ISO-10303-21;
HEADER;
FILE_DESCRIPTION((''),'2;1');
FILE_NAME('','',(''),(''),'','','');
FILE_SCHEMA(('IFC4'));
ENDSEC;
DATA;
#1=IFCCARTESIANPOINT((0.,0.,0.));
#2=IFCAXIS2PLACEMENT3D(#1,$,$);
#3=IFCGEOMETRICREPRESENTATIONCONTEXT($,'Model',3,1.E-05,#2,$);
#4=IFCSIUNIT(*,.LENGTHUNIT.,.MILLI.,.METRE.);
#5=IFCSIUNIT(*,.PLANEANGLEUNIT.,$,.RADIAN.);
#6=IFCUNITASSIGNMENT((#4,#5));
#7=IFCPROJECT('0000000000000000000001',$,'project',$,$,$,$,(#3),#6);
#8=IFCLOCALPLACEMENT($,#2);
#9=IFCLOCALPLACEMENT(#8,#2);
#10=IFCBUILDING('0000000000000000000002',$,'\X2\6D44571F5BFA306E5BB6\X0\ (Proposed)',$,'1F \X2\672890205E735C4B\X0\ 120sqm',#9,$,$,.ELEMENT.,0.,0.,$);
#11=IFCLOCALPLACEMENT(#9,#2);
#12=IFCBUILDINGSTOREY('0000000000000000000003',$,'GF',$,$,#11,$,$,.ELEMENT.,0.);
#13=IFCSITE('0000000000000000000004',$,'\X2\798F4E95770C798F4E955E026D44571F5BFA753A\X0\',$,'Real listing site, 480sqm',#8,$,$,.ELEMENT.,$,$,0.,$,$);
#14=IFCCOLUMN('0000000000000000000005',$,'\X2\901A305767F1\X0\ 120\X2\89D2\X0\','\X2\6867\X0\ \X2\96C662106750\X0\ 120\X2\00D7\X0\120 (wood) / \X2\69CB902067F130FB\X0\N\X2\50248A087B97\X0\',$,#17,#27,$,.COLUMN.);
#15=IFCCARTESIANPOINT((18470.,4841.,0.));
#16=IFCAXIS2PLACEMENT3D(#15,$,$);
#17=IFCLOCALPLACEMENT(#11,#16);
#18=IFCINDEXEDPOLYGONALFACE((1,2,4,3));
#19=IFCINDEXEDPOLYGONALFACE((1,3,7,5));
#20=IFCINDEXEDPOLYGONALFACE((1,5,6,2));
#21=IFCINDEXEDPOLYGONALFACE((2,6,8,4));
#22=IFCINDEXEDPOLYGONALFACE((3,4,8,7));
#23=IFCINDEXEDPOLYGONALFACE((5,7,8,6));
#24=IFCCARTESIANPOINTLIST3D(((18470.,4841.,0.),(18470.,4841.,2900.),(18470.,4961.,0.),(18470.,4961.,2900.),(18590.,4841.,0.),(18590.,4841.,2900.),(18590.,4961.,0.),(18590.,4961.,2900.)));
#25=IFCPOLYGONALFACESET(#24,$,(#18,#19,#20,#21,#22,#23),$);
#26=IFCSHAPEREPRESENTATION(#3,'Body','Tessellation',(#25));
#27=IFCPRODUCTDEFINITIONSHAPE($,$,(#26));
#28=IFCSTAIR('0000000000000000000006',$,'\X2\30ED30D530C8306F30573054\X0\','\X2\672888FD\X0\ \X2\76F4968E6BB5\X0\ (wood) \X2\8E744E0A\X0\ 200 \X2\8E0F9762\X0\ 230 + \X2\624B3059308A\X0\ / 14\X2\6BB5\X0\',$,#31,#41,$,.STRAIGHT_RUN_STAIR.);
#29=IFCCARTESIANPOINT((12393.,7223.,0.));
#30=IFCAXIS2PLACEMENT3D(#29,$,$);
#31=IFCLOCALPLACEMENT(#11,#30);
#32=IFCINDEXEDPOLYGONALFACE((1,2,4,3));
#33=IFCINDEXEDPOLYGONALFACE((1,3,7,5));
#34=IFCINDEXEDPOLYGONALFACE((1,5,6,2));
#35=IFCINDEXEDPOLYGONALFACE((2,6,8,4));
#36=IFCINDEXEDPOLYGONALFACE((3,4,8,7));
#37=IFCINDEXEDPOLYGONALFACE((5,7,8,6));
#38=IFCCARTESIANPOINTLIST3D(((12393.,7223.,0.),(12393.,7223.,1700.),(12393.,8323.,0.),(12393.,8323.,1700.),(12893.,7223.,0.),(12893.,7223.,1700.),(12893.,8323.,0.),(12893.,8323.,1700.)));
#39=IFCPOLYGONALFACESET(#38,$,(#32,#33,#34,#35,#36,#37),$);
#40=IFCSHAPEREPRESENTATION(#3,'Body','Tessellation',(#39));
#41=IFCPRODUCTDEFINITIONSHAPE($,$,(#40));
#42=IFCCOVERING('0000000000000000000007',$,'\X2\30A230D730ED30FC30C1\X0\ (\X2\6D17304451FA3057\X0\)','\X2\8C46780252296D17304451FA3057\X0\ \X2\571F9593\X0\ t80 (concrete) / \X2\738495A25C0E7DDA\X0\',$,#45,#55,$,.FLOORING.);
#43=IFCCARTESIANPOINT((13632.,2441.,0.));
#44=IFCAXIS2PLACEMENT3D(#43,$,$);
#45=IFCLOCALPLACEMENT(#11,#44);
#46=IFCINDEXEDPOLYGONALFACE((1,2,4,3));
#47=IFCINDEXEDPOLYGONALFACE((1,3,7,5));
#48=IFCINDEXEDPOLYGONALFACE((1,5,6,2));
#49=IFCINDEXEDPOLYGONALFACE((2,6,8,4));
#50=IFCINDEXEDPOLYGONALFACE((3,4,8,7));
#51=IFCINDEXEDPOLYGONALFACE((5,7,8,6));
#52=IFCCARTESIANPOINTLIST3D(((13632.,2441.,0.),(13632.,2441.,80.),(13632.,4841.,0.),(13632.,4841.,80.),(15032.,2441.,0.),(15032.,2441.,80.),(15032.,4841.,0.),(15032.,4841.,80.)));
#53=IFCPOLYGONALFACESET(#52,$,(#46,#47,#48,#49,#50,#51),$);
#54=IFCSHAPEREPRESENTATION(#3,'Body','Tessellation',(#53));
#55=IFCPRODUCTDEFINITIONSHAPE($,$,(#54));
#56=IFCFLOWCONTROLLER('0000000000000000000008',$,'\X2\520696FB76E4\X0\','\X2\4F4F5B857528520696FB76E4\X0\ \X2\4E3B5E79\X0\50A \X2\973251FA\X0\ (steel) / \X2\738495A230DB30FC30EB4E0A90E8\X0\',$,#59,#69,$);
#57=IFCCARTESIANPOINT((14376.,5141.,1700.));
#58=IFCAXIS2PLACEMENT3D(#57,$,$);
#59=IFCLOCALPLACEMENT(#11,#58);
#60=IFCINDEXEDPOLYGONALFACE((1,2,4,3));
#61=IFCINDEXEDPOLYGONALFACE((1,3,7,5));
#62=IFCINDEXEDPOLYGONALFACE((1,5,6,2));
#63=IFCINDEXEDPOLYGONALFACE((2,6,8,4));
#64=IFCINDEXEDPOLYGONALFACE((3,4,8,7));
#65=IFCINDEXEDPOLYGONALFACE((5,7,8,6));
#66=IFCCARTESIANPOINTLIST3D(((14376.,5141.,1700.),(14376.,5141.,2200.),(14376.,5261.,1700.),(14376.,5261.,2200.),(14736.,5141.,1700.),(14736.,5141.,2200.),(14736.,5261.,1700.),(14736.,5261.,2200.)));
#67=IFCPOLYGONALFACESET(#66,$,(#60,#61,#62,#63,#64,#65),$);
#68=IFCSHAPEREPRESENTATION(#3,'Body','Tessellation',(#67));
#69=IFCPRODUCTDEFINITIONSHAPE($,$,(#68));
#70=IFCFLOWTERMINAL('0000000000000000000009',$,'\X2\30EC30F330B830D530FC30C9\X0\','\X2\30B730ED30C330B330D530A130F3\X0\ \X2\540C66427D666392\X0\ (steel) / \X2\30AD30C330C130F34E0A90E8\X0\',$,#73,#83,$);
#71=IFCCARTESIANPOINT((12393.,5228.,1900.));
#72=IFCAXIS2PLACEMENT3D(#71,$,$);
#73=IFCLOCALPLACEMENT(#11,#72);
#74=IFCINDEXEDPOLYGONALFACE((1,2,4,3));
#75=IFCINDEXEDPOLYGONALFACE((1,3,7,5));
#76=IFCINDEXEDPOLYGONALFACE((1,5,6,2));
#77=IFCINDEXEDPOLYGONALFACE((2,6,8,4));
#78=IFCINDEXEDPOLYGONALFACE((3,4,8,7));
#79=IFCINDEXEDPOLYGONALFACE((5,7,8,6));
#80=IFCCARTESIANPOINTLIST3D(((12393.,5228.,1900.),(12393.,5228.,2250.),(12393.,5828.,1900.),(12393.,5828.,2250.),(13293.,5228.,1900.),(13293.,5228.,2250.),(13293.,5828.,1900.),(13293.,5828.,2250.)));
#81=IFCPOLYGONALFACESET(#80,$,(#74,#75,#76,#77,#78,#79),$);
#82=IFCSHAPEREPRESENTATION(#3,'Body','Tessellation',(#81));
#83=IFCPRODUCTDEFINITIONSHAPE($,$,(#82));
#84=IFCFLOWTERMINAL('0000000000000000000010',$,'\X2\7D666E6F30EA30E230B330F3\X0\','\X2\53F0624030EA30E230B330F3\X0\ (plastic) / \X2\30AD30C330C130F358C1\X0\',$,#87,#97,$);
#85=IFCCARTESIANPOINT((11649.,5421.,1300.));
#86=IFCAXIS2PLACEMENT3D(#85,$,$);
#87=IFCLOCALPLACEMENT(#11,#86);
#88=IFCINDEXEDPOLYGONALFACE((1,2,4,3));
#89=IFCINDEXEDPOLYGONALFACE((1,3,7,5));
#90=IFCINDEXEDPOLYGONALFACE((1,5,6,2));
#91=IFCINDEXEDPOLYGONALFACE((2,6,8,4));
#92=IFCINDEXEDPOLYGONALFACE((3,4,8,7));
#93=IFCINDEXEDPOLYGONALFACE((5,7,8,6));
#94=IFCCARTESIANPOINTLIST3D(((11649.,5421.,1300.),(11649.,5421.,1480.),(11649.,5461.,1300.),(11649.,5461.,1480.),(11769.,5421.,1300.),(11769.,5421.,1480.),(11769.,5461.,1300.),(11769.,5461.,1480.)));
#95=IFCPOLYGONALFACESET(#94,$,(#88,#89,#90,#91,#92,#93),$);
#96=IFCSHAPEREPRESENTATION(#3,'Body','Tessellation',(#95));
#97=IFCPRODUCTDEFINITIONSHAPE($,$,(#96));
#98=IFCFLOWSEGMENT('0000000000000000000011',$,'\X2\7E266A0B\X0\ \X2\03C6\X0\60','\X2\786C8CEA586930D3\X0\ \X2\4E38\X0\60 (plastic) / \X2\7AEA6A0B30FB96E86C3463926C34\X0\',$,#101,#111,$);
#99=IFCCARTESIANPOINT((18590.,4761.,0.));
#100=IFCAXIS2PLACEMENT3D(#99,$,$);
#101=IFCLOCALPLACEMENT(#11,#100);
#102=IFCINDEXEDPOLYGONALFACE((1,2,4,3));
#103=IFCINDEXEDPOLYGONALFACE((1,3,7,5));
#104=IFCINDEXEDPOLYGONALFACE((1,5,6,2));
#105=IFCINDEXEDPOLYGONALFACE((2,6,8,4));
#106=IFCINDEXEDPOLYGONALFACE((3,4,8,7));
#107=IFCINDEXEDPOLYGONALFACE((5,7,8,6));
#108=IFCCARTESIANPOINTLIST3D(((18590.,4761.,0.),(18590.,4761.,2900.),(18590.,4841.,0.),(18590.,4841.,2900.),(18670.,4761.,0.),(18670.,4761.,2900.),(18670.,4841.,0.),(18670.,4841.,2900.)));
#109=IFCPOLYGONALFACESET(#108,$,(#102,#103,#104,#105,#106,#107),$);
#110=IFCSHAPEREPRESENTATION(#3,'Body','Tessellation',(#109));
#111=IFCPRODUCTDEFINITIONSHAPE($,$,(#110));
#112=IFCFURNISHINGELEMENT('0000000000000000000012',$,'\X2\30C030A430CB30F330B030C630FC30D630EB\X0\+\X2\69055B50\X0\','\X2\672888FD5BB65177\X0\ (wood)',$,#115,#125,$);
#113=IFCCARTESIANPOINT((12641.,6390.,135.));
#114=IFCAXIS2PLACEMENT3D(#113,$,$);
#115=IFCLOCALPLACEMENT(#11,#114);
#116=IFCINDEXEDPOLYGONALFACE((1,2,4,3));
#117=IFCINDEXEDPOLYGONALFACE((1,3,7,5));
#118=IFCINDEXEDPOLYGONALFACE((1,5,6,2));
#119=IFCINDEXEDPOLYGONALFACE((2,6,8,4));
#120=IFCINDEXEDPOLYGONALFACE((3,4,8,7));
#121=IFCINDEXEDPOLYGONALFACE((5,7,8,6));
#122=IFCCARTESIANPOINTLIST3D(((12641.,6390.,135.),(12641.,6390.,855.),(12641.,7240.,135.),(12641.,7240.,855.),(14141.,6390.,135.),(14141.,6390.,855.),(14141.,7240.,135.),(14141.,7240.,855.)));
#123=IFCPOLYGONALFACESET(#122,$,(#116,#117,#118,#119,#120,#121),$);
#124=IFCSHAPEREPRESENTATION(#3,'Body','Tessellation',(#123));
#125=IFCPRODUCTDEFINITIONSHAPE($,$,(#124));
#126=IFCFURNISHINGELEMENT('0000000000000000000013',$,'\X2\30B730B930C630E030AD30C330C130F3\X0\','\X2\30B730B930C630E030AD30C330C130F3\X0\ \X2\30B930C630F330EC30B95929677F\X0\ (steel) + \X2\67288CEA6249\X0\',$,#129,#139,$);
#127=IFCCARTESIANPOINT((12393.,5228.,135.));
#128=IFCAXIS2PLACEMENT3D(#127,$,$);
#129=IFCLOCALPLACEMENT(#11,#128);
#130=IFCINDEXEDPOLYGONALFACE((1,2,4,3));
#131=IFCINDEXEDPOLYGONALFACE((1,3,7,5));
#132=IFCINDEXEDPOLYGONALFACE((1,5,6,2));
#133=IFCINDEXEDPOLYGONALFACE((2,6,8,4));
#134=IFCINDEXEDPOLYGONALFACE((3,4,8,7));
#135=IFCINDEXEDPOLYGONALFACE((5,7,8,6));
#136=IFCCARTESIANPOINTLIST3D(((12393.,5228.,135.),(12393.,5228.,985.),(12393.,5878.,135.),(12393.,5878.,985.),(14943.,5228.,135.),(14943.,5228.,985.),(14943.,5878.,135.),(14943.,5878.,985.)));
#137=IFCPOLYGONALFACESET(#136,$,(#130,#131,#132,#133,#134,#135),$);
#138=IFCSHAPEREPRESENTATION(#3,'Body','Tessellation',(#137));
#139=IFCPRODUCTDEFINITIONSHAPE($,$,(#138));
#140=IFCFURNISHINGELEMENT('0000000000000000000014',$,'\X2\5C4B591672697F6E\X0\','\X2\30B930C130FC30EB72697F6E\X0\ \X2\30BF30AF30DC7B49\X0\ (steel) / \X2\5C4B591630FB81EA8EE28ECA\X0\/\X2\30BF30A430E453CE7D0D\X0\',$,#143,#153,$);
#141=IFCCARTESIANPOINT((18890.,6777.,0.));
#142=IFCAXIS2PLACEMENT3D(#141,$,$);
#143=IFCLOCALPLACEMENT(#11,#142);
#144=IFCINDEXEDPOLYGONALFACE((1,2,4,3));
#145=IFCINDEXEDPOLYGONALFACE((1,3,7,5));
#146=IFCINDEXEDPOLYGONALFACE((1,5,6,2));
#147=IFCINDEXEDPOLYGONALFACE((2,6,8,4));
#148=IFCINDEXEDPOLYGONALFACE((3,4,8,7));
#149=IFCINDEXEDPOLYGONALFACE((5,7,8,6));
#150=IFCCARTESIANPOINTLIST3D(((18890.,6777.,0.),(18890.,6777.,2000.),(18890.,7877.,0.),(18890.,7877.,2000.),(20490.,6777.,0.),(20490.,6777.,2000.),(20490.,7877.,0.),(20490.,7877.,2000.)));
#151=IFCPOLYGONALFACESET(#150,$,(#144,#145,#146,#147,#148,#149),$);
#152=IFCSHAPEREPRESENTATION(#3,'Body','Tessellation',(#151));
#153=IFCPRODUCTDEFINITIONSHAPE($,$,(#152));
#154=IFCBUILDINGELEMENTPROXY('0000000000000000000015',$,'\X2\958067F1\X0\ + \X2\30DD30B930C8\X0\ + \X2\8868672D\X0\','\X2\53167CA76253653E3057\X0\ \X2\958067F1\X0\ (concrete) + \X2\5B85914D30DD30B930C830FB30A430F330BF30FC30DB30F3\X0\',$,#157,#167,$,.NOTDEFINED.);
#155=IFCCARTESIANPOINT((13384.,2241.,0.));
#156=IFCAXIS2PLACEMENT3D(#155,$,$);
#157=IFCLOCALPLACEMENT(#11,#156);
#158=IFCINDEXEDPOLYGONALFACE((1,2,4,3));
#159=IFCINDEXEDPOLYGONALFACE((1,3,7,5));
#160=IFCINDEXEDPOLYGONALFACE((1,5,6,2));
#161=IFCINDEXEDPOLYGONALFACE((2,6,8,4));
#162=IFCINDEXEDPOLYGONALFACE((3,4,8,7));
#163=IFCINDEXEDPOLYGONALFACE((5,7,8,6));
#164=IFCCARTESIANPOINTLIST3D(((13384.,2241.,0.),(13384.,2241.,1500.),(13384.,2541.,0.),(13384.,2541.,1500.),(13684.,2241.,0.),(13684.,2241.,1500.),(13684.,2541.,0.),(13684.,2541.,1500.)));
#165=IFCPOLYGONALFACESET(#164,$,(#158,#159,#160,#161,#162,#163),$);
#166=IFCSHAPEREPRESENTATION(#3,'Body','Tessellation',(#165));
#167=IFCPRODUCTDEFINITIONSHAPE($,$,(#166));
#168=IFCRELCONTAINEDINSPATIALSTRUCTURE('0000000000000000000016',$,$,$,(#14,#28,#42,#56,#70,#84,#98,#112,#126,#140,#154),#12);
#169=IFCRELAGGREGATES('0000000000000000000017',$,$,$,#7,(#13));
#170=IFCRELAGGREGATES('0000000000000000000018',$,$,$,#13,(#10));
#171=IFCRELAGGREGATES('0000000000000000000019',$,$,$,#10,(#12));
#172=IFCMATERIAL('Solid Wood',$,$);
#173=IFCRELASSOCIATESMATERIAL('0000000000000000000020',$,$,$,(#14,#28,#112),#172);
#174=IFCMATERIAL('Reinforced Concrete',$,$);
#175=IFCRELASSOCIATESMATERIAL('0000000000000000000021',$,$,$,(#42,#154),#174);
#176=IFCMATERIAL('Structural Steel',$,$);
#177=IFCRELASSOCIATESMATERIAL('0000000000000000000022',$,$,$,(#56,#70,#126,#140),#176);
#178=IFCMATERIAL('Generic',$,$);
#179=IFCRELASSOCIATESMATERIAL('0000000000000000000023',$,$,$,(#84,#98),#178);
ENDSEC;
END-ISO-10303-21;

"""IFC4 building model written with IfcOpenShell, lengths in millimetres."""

from ifc_helpers import new_model, si_unit, frame, frame_2d, origin, place, context, project, spatial, rectangle, extrude, material, element, save


model = new_model("IFC4")

# Units and contexts
model_context = context("Model", 3, precision=1e-05, world=origin())
ifc_project = project(units=[si_unit("LENGTHUNIT", "METRE", prefix="MILLI"), si_unit("PLANEANGLEUNIT", "RADIAN")], contexts=[model_context])

# Site, building, storey
site_placement = place(None, origin())
site = spatial("IfcSite", under=ifc_project, at=site_placement, Name="福井県福井市浄土寺町", ObjectType="Real listing site, 480sqm", CompositionType="ELEMENT", RefElevation=0.0)
building_placement = place(site_placement, origin())
building = spatial("IfcBuilding", under=site, at=building_placement, Name="浄土寺の家 (Proposed)", ObjectType="1F 木造平屋 120sqm", CompositionType="ELEMENT", ElevationOfRefHeight=0.0, ElevationOfTerrain=0.0)
storey_placement = place(building_placement, origin())
storey = spatial("IfcBuildingStorey", under=building, at=storey_placement, Name="GF", CompositionType="ELEMENT", Elevation=0.0)

# Column
ifc_material_1 = material(Name="Solid Wood")
column_1_placement = place(storey_placement, frame((18470.0, 4841.0, 0.0)))
element("IfcColumn", 1, at=column_1_placement, inside=storey, material=ifc_material_1, Name="通し柱 120角", Description="桧 集成材 120×120 (wood) / 構造柱・N値計算", PredefinedType="COLUMN", context=model_context, shape_type="SweptSolid", body=[
    extrude(rectangle(XDim=120.0, YDim=120.0, at=frame_2d((60.0, 60.0))), frame((18470.0, 4841.0, 0.0)), (0.0, 0.0, 1.0), 2900.0),
])

# Stair
stair_placement = place(storey_placement, frame((12393.0, 7223.0, 0.0)))
element("IfcStair", 2, at=stair_placement, inside=storey, material=ifc_material_1, Name="ロフトはしご", Description="木製 直階段 (wood) 蹴上 200 踏面 230 + 手すり / 14段", PredefinedType="STRAIGHT_RUN_STAIR", context=model_context, shape_type="SweptSolid", body=[
    extrude(rectangle(XDim=500.0, YDim=1100.0, at=frame_2d((250.0, 550.0))), frame((12393.0, 7223.0, 0.0)), (0.0, 0.0, 1.0), 1700.0),
])

# Covering
ifc_material_2 = material(Name="Reinforced Concrete")
covering_placement = place(storey_placement, frame((13632.0, 2441.0, 0.0)))
element("IfcCovering", 3, at=covering_placement, inside=storey, material=ifc_material_2, Name="アプローチ (洗い出し)", Description="豆砂利洗い出し 土間 t80 (concrete) / 玄関導線", PredefinedType="FLOORING", context=model_context, shape_type="SweptSolid", body=[
    extrude(rectangle(XDim=1400.0, YDim=2400.0, at=frame_2d((700.0, 1200.0))), frame((13632.0, 2441.0, 0.0)), (0.0, 0.0, 1.0), 80.0),
])

# Flow controller
ifc_material_3 = material(Name="Structural Steel")
flow_controller_placement = place(storey_placement, frame((14376.0, 5141.0, 1700.0)))
element("IfcFlowController", 4, at=flow_controller_placement, inside=storey, material=ifc_material_3, Name="分電盤", Description="住宅用分電盤 主幹50A 露出 (steel) / 玄関ホール上部", context=model_context, shape_type="SweptSolid", body=[
    extrude(rectangle(XDim=360.0, YDim=120.0, at=frame_2d((180.0, 60.0))), frame((14376.0, 5141.0, 1700.0)), (0.0, 0.0, 1.0), 500.0),
])

# Flow terminals
flow_terminal_1_placement = place(storey_placement, frame((12393.0, 5228.0, 1900.0)))
element("IfcFlowTerminal", 5, at=flow_terminal_1_placement, inside=storey, material=ifc_material_3, Name="レンジフード", Description="シロッコファン 同時給排 (steel) / キッチン上部", context=model_context, shape_type="SweptSolid", body=[
    extrude(rectangle(XDim=900.0, YDim=600.0, at=frame_2d((450.0, 300.0))), frame((12393.0, 5228.0, 1900.0)), (0.0, 0.0, 1.0), 350.0),
])
ifc_material_4 = material(Name="Generic")
flow_terminal_2_placement = place(storey_placement, frame((11649.0, 5421.0, 1300.0)))
element("IfcFlowTerminal", 6, at=flow_terminal_2_placement, inside=storey, material=ifc_material_4, Name="給湯リモコン", Description="台所リモコン (plastic) / キッチン壁", context=model_context, shape_type="SweptSolid", body=[
    extrude(rectangle(XDim=120.0, YDim=40.0, at=frame_2d((60.0, 20.0))), frame((11649.0, 5421.0, 1300.0)), (0.0, 0.0, 1.0), 180.0),
])

# Flow segment
flow_segment_placement = place(storey_placement, frame((18590.0, 4761.0, 0.0)))
element("IfcFlowSegment", 7, at=flow_segment_placement, inside=storey, material=ifc_material_4, Name="縦樋 φ60", Description="硬質塩ビ 丸60 (plastic) / 竪樋・雨水排水", context=model_context, shape_type="SweptSolid", body=[
    extrude(rectangle(XDim=80.0, YDim=80.0, at=frame_2d((40.0, 40.0))), frame((18590.0, 4761.0, 0.0)), (0.0, 0.0, 1.0), 2900.0),
])

# Furnishing elements
furnishing_1_placement = place(storey_placement, frame((12641.0, 6390.0, 135.0)))
element("IfcFurnishingElement", 8, at=furnishing_1_placement, inside=storey, material=ifc_material_1, Name="ダイニングテーブル+椅子", Description="木製家具 (wood)", context=model_context, shape_type="SweptSolid", body=[
    extrude(rectangle(XDim=1500.0, YDim=850.0, at=frame_2d((750.0, 425.0))), frame((12641.0, 6390.0, 135.0)), (0.0, 0.0, 1.0), 720.0),
])
furnishing_2_placement = place(storey_placement, frame((12393.0, 5228.0, 135.0)))
element("IfcFurnishingElement", 9, at=furnishing_2_placement, inside=storey, material=ifc_material_3, Name="システムキッチン", Description="システムキッチン ステンレス天板 (steel) + 木質扉", context=model_context, shape_type="SweptSolid", body=[
    extrude(rectangle(XDim=2550.0, YDim=650.0, at=frame_2d((1275.0, 325.0))), frame((12393.0, 5228.0, 135.0)), (0.0, 0.0, 1.0), 850.0),
])
furnishing_3_placement = place(storey_placement, frame((18890.0, 6777.0, 0.0)))
element("IfcFurnishingElement", 10, at=furnishing_3_placement, inside=storey, material=ifc_material_3, Name="屋外物置", Description="スチール物置 タクボ等 (steel) / 屋外・自転車/タイヤ収納", context=model_context, shape_type="SweptSolid", body=[
    extrude(rectangle(XDim=1600.0, YDim=1100.0, at=frame_2d((800.0, 550.0))), frame((18890.0, 6777.0, 0.0)), (0.0, 0.0, 1.0), 2000.0),
])

# Building element proxy
proxy_placement = place(storey_placement, frame((13384.0, 2241.0, 0.0)))
element("IfcBuildingElementProxy", 11, at=proxy_placement, inside=storey, material=ifc_material_2, Name="門柱 + ポスト + 表札", Description="化粧打放し 門柱 (concrete) + 宅配ポスト・インターホン", PredefinedType="NOTDEFINED", context=model_context, shape_type="SweptSolid", body=[
    extrude(rectangle(XDim=300.0, YDim=300.0, at=frame_2d((150.0, 150.0))), frame((13384.0, 2241.0, 0.0)), (0.0, 0.0, 1.0), 1500.0),
])

save(model, "model.ifc")
